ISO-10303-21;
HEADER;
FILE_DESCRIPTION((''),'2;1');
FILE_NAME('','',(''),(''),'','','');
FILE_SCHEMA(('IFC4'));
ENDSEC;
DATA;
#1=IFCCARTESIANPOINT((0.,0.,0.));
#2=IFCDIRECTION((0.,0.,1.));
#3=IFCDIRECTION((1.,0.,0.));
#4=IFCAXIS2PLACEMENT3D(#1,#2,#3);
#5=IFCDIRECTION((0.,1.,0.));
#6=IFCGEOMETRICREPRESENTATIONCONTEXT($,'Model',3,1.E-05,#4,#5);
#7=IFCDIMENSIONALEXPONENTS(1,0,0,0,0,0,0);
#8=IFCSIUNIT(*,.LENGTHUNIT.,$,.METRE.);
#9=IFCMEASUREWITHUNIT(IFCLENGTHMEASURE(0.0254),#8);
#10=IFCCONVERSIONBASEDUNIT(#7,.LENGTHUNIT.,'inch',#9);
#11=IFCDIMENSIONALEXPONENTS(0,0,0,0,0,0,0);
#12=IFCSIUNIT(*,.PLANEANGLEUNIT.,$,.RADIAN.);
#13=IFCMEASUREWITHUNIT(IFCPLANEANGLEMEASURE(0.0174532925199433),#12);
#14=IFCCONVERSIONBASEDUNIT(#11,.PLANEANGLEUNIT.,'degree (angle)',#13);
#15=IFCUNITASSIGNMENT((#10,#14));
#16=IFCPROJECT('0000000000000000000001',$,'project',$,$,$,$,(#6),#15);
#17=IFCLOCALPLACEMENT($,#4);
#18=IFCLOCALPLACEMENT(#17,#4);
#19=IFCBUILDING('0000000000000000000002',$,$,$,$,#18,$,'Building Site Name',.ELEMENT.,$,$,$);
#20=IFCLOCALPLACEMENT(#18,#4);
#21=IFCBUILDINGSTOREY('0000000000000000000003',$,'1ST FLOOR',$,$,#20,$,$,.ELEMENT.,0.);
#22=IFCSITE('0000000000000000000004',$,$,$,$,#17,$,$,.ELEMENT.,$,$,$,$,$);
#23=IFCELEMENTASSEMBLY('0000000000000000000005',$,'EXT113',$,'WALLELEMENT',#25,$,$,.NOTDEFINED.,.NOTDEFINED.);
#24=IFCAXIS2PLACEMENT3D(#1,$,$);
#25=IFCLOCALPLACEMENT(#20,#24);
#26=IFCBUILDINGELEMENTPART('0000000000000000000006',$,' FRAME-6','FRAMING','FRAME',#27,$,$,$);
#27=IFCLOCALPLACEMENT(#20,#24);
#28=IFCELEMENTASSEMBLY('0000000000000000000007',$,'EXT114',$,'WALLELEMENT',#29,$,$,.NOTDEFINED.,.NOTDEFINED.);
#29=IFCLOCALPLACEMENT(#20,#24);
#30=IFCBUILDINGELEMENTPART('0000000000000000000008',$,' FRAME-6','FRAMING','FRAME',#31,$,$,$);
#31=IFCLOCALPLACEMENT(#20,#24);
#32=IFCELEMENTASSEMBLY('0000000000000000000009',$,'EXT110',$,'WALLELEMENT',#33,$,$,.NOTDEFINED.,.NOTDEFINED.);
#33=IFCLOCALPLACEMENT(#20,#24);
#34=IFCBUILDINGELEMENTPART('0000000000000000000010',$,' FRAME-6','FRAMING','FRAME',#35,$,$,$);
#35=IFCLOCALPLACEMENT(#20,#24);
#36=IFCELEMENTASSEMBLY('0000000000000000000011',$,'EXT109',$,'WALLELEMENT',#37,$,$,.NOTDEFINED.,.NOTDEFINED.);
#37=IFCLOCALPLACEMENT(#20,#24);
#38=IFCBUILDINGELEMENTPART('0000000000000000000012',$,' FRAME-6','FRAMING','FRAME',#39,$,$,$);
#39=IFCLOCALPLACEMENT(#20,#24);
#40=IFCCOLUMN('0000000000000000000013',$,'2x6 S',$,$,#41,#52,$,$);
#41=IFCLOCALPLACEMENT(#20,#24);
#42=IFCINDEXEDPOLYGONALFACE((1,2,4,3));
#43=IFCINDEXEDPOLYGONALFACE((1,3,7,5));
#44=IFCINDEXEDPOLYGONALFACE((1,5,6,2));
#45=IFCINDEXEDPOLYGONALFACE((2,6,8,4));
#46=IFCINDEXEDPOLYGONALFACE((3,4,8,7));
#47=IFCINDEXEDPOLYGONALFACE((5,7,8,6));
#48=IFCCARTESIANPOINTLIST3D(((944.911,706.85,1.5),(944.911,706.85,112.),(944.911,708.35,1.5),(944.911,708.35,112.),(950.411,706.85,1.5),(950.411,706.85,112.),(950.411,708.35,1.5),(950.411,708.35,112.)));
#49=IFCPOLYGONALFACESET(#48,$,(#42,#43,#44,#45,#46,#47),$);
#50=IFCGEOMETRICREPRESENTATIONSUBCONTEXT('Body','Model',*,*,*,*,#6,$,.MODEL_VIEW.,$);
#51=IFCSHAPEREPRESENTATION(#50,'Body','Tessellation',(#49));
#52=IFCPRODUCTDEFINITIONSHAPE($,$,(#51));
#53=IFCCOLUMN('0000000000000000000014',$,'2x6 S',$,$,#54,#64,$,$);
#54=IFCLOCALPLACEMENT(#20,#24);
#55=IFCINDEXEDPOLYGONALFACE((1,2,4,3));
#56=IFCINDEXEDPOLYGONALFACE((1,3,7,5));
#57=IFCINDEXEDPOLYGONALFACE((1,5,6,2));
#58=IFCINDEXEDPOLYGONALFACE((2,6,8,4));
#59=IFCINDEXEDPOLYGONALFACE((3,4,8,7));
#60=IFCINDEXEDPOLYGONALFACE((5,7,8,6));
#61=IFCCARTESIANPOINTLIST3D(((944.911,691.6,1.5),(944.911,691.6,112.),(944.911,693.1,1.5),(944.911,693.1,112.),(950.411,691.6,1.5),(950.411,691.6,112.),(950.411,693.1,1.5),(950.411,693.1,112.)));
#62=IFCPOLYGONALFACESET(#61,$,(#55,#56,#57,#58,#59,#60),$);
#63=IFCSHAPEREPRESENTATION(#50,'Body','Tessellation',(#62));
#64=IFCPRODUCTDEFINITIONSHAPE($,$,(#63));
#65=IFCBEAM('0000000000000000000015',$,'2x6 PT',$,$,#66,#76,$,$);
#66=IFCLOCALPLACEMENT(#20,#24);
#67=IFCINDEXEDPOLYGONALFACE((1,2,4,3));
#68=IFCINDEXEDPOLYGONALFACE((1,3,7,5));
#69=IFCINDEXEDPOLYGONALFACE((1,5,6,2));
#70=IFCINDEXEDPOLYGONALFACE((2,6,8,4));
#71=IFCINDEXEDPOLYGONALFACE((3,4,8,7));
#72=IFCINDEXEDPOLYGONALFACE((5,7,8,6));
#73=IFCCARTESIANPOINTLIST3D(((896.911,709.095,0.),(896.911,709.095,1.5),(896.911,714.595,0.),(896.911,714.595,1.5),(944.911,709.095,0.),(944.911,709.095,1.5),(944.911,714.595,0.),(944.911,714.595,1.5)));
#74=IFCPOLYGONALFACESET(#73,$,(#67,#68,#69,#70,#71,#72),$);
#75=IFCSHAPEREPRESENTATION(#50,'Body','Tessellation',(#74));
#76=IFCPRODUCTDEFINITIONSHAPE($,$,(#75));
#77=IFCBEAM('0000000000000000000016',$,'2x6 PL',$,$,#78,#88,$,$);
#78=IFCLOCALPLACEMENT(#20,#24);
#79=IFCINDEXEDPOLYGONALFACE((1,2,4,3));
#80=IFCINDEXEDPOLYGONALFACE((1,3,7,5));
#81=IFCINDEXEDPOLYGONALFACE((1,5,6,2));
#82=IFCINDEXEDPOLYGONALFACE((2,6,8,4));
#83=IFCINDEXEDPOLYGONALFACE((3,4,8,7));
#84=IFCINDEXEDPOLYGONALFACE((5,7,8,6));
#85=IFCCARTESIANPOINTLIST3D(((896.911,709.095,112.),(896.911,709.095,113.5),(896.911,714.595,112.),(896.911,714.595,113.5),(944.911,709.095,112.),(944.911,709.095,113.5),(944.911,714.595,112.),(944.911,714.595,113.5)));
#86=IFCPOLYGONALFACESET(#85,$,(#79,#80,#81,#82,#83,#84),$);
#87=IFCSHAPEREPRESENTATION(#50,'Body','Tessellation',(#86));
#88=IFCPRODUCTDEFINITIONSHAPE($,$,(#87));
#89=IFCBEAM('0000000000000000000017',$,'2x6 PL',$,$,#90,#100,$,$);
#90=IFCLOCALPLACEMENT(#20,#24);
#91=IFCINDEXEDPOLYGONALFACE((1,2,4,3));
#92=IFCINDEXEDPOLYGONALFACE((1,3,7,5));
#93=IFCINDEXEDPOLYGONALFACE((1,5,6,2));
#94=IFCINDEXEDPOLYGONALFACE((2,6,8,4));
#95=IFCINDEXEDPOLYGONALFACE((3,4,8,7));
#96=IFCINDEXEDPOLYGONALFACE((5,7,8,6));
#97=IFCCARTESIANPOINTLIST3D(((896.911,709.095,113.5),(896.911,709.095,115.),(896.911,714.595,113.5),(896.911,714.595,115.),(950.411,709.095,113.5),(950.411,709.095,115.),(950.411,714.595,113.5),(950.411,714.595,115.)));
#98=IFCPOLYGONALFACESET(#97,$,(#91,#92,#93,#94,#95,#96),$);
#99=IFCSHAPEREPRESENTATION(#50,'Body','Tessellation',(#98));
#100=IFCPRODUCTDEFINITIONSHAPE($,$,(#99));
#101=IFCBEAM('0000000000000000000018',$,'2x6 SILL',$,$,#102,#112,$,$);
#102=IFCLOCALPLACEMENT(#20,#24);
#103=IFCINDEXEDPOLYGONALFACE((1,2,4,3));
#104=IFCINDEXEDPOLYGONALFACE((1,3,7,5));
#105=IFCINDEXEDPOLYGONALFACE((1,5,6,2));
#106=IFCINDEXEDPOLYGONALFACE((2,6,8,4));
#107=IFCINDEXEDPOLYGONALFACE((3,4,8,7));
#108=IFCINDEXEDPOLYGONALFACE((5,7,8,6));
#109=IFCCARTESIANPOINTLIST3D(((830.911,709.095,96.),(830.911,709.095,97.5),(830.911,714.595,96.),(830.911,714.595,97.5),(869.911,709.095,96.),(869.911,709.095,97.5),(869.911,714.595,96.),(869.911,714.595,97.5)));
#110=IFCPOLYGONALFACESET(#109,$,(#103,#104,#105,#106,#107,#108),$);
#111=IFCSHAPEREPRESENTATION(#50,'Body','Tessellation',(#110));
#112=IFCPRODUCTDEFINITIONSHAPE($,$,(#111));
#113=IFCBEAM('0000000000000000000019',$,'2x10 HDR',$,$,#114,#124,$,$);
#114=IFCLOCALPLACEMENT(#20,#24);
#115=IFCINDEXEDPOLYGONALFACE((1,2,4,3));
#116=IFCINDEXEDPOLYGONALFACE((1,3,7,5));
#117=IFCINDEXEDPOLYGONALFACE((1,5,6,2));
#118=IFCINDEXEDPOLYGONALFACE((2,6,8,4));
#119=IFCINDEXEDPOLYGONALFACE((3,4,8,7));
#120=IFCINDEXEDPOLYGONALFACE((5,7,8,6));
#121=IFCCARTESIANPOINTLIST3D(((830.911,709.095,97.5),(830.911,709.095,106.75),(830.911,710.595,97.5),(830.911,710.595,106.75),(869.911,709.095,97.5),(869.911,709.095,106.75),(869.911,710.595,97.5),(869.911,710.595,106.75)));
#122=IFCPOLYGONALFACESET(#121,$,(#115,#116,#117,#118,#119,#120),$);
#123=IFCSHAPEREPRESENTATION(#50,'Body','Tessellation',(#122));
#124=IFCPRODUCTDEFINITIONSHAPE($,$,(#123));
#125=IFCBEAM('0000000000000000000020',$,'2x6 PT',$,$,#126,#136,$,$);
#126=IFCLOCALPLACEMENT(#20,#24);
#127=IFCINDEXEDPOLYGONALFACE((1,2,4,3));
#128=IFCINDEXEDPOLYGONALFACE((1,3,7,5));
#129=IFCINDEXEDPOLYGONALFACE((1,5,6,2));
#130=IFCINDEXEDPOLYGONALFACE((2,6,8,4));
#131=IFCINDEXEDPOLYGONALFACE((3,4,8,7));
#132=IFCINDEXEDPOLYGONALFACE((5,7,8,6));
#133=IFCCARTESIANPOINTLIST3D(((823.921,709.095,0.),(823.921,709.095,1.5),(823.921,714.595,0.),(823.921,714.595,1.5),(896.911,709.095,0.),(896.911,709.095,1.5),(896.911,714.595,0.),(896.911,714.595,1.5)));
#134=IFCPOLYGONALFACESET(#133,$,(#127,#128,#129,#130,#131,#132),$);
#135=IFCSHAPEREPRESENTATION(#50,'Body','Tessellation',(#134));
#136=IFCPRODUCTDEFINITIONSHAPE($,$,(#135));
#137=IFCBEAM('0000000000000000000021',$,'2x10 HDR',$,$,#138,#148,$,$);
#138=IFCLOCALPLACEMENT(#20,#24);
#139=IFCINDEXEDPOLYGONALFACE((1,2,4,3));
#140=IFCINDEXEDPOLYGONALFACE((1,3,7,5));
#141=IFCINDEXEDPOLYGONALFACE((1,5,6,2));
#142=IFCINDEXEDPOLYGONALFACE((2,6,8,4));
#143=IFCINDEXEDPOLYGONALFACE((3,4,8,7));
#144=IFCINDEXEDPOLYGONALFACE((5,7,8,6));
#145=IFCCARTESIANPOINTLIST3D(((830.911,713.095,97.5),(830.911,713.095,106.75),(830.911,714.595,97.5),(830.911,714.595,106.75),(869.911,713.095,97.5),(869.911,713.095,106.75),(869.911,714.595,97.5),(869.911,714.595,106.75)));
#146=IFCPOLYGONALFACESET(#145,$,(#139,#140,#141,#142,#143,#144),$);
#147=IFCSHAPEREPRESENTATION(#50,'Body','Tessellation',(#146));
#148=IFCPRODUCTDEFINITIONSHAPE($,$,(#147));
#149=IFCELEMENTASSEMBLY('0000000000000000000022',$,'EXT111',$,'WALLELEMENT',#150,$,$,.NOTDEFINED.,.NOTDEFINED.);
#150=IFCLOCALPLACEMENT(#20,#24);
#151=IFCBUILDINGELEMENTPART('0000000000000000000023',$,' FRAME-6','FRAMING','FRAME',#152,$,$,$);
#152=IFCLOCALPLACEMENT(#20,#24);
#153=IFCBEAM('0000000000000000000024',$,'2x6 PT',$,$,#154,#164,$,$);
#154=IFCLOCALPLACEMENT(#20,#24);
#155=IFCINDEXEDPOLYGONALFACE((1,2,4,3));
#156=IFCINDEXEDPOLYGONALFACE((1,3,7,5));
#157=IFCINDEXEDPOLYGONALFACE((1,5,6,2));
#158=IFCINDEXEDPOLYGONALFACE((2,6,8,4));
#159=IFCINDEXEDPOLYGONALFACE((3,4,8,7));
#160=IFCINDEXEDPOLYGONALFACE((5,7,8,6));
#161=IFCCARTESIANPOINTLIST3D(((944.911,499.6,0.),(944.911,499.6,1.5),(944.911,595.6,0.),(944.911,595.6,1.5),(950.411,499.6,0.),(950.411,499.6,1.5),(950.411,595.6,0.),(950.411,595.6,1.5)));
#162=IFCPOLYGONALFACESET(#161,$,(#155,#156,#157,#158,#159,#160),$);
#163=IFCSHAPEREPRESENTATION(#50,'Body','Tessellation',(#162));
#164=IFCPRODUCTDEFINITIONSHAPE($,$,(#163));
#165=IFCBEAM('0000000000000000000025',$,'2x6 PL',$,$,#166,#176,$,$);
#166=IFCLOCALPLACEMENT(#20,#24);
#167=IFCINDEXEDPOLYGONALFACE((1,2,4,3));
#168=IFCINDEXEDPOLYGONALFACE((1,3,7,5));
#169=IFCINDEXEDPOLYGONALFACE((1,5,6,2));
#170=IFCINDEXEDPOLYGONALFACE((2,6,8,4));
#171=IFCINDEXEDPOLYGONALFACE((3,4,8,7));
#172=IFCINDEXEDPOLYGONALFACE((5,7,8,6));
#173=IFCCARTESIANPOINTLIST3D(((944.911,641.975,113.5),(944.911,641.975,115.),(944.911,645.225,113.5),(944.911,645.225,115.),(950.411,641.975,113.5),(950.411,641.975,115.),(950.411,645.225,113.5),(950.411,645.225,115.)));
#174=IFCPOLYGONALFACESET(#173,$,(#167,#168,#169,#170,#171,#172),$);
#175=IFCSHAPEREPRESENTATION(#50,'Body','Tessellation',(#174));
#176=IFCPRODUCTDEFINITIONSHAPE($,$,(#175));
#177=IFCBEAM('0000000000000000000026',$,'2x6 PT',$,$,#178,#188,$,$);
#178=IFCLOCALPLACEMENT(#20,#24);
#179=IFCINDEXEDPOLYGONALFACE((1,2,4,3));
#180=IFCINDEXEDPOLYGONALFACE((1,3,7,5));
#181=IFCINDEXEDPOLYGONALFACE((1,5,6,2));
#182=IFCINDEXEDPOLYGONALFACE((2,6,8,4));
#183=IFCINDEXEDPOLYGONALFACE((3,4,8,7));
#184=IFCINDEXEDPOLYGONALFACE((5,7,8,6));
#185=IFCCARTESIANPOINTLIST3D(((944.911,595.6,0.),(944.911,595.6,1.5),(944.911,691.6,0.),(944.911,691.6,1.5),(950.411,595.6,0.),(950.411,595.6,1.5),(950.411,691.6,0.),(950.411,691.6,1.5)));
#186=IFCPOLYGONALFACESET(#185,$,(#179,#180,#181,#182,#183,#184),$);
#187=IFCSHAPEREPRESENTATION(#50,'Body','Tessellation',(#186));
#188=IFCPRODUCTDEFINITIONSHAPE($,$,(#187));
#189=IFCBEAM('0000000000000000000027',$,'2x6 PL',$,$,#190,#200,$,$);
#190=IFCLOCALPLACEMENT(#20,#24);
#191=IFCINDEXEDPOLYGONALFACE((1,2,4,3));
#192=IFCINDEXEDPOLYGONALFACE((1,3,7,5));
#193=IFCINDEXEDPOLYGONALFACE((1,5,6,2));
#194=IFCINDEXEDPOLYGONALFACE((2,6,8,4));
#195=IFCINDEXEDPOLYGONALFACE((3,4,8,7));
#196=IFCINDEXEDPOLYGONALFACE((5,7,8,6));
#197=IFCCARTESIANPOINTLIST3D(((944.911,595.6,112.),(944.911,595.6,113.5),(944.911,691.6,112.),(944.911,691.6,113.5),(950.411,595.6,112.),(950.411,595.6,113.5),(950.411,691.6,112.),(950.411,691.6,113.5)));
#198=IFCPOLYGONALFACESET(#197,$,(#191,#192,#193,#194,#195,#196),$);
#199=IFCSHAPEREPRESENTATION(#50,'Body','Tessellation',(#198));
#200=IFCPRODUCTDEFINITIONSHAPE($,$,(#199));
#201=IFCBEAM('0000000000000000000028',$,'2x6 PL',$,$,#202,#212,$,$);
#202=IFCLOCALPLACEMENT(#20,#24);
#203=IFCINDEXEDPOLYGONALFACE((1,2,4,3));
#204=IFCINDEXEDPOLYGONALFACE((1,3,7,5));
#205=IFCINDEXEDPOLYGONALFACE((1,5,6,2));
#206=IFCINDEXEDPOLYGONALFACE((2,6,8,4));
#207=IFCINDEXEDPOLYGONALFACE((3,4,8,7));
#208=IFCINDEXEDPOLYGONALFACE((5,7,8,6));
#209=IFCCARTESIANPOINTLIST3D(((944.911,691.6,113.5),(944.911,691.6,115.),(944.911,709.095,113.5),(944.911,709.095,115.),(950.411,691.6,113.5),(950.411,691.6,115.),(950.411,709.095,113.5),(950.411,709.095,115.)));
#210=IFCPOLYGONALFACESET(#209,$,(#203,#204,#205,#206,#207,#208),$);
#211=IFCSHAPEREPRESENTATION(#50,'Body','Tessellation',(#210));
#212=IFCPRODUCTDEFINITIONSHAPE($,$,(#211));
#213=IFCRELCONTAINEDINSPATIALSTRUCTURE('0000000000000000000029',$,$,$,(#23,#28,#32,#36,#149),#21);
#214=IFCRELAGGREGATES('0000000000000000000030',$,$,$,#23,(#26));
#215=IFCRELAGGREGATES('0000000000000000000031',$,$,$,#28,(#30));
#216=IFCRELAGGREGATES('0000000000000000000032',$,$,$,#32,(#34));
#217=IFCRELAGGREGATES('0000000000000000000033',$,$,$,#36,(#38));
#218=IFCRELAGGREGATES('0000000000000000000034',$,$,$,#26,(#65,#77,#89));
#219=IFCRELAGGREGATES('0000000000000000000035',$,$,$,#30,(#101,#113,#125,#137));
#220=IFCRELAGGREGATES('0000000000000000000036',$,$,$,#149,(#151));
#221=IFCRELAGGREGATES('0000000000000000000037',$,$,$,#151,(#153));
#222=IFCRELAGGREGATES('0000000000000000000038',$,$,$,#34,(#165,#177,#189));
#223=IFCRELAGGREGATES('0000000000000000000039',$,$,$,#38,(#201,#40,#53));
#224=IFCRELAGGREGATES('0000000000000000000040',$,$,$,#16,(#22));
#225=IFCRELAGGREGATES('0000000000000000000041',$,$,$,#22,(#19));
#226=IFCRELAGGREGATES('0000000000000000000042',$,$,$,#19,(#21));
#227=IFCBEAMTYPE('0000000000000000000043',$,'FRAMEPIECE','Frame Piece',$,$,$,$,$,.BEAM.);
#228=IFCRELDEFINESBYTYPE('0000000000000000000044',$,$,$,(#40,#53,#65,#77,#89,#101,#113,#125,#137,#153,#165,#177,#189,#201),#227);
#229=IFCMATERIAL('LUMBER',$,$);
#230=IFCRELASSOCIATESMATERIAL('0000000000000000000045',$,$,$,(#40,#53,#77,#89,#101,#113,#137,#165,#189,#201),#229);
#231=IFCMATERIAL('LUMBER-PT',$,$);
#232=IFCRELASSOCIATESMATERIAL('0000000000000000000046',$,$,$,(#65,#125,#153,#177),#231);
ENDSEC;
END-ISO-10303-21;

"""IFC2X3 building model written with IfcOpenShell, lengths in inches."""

from ifc_helpers import new_model, entity, si_unit, converted_unit, direction, frame, frame_2d, origin_with_axes, place, context, subcontext, project, spatial, rectangle, extrude, material, type_object, element, aggregate, save


model = new_model("IFC2X3")

# Units and contexts
model_context = context("Model", 3, precision=1e-05, world=origin_with_axes(), true_north=direction((0.0, 1.0, 0.0)))
body_context = subcontext(model_context, "Body", "Model", "MODEL_VIEW")
ifc_project = project(units=[converted_unit("LENGTHUNIT", "inch", entity("IfcLengthMeasure", 0.0254), si_unit("LENGTHUNIT", "METRE"), dimensions=[1, 0, 0, 0, 0, 0, 0]), converted_unit("PLANEANGLEUNIT", "degree (angle)", entity("IfcPlaneAngleMeasure", 0.0174532925199433), si_unit("PLANEANGLEUNIT", "RADIAN"), dimensions=[0, 0, 0, 0, 0, 0, 0])], contexts=[model_context])

# Site, building, storey
site_placement = place(None, origin_with_axes())
site = spatial("IfcSite", under=ifc_project, at=site_placement, CompositionType="ELEMENT")
building_placement = place(site_placement, origin_with_axes())
building = spatial("IfcBuilding", under=site, at=building_placement, LongName="Building Site Name", CompositionType="ELEMENT")
storey_placement = place(building_placement, origin_with_axes())
storey = spatial("IfcBuildingStorey", under=building, at=storey_placement, Name="1ST FLOOR", CompositionType="ELEMENT", Elevation=0.0)

# Element assemblies, building element parts, columns
assembly_1_placement = place(storey_placement, origin_with_axes())
assembly_1 = element("IfcElementAssembly", 1, at=assembly_1_placement, inside=storey, Name="EXT113", ObjectType="WALLELEMENT", AssemblyPlace="NOTDEFINED", PredefinedType="NOTDEFINED")
building_element_part_1 = element("IfcBuildingElementPart", 2, Name=" FRAME-6", Description="FRAMING", ObjectType="FRAME")
aggregate(assembly_1, [building_element_part_1])
ifc_material_1 = material(Name="LUMBER")
beam_type = type_object("IfcBeamType", Name="FRAMEPIECE", Description="Frame Piece", PredefinedType="BEAM")
assembly_2_placement = place(storey_placement, origin_with_axes())
assembly_2 = element("IfcElementAssembly", 3, at=assembly_2_placement, inside=storey, Name="EXT114", ObjectType="WALLELEMENT", AssemblyPlace="NOTDEFINED", PredefinedType="NOTDEFINED")
building_element_part_2 = element("IfcBuildingElementPart", 4, Name=" FRAME-6", Description="FRAMING", ObjectType="FRAME")
aggregate(assembly_2, [building_element_part_2])
assembly_3_placement = place(storey_placement, origin_with_axes())
assembly_3 = element("IfcElementAssembly", 5, at=assembly_3_placement, inside=storey, Name="EXT110", ObjectType="WALLELEMENT", AssemblyPlace="NOTDEFINED", PredefinedType="NOTDEFINED")
building_element_part_3 = element("IfcBuildingElementPart", 6, Name=" FRAME-6", Description="FRAMING", ObjectType="FRAME")
aggregate(assembly_3, [building_element_part_3])
assembly_4_placement = place(storey_placement, origin_with_axes())
assembly_4 = element("IfcElementAssembly", 7, at=assembly_4_placement, inside=storey, Name="EXT109", ObjectType="WALLELEMENT", AssemblyPlace="NOTDEFINED", PredefinedType="NOTDEFINED")
building_element_part_4 = element("IfcBuildingElementPart", 8, Name=" FRAME-6", Description="FRAMING", ObjectType="FRAME")
aggregate(assembly_4, [building_element_part_4])
column_1_placement = place(assembly_4_placement, frame((947.661, 707.6, 112.0), z_axis=(0.0, 0.0, -1.0), x_axis=(0.0, -1.0, 0.0)))
column_1 = element("IfcColumn", 9, at=column_1_placement, type_object=beam_type, material=ifc_material_1, Name="2x6 S", context=body_context, shape_type="SweptSolid", body=[
    extrude(rectangle(XDim=1.5, YDim=5.5, at=frame_2d((0.0, 0.0), x_axis=(-1.0, 0.0))), origin_with_axes(), (0.0, 0.0, 1.0), 110.5),
])
column_2_placement = place(assembly_4_placement, frame((947.661, 692.35, 1.5), z_axis=(0.0, 0.0, 1.0), x_axis=(0.0, 1.0, 0.0)))
column_2 = element("IfcColumn", 10, at=column_2_placement, type_object=beam_type, material=ifc_material_1, Name="2x6 S", context=body_context, shape_type="SweptSolid", body=[
    extrude(rectangle(XDim=1.5, YDim=5.5, at=frame_2d((0.0, 0.0), x_axis=(-1.0, 0.0))), frame((0.0, 0.0, 0.0), z_axis=(0.0, 0.0, 1.0), x_axis=(1.0, 0.0, 0.0)), (0.0, 0.0, 1.0), 110.5),
])

# Beams
ifc_material_2 = material(Name="LUMBER-PT")
beam_1_placement = place(assembly_1_placement, frame((944.911, 711.845, 0.75), z_axis=(-1.0, 0.0, 0.0), x_axis=(0.0, 0.0, 1.0)))
beam_1 = element("IfcBeam", 11, at=beam_1_placement, type_object=beam_type, material=ifc_material_2, Name="2x6 PT", context=body_context, shape_type="SweptSolid", body=[
    extrude(rectangle(XDim=1.5, YDim=5.5, at=frame_2d((0.0, 0.0), x_axis=(-1.0, 0.0))), origin_with_axes(), (0.0, 0.0, 1.0), 48.0),
])
beam_2_placement = place(assembly_1_placement, frame((896.911, 711.845, 112.75), z_axis=(1.0, 0.0, 0.0), x_axis=(0.0, 0.0, -1.0)))
beam_2 = element("IfcBeam", 12, at=beam_2_placement, type_object=beam_type, material=ifc_material_1, Name="2x6 PL", context=body_context, shape_type="SweptSolid", body=[
    extrude(rectangle(XDim=1.5, YDim=5.5, at=frame_2d((0.0, 0.0), x_axis=(-1.0, 0.0))), origin_with_axes(), (0.0, 0.0, 1.0), 48.0),
])
beam_3_placement = place(assembly_1_placement, frame((896.911, 711.845, 114.25), z_axis=(1.0, 0.0, 0.0), x_axis=(0.0, 0.0, -1.0)))
beam_3 = element("IfcBeam", 13, at=beam_3_placement, type_object=beam_type, material=ifc_material_1, Name="2x6 PL", context=body_context, shape_type="SweptSolid", body=[
    extrude(rectangle(XDim=1.5, YDim=5.5, at=frame_2d((0.0, 0.0), x_axis=(-1.0, 0.0))), origin_with_axes(), (0.0, 0.0, 1.0), 53.5),
])
aggregate(building_element_part_1, [beam_1, beam_2, beam_3])
beam_4_placement = place(assembly_2_placement, frame((869.911, 711.845, 96.75), z_axis=(-1.0, 0.0, 0.0), x_axis=(0.0, 0.0, 1.0)))
beam_4 = element("IfcBeam", 14, at=beam_4_placement, type_object=beam_type, material=ifc_material_1, Name="2x6 SILL", context=body_context, shape_type="SweptSolid", body=[
    extrude(rectangle(XDim=1.5, YDim=5.5, at=frame_2d((0.0, 0.0), x_axis=(-1.0, 0.0))), frame((0.0, 0.0, 0.0), z_axis=(0.0, 0.0, 1.0), x_axis=(1.0, 0.0, 0.0)), (0.0, 0.0, 1.0), 39.0),
])
beam_5_placement = place(assembly_2_placement, frame((869.911, 709.845, 102.125), z_axis=(-1.0, 0.0, 0.0), x_axis=(0.0, -1.0, 0.0)))
beam_5 = element("IfcBeam", 15, at=beam_5_placement, type_object=beam_type, material=ifc_material_1, Name="2x10 HDR", context=body_context, shape_type="SweptSolid", body=[
    extrude(rectangle(XDim=1.5, YDim=9.25, at=frame_2d((0.0, 0.0), x_axis=(-1.0, 0.0))), origin_with_axes(), (0.0, 0.0, 1.0), 39.0),
])
beam_6_placement = place(assembly_2_placement, frame((896.911, 711.845, 0.75), z_axis=(-1.0, 0.0, 0.0), x_axis=(0.0, 0.0, 1.0)))
beam_6 = element("IfcBeam", 16, at=beam_6_placement, type_object=beam_type, material=ifc_material_2, Name="2x6 PT", context=body_context, shape_type="SweptSolid", body=[
    extrude(rectangle(XDim=1.5, YDim=5.5, at=frame_2d((0.0, 0.0), x_axis=(-1.0, 0.0))), origin_with_axes(), (0.0, 0.0, 1.0), 72.99),
])
beam_7_placement = place(assembly_2_placement, frame((869.911, 713.845, 102.125), z_axis=(-1.0, 0.0, 0.0), x_axis=(0.0, -1.0, 0.0)))
beam_7 = element("IfcBeam", 17, at=beam_7_placement, type_object=beam_type, material=ifc_material_1, Name="2x10 HDR", context=body_context, shape_type="SweptSolid", body=[
    extrude(rectangle(XDim=1.5, YDim=9.25, at=frame_2d((0.0, 0.0), x_axis=(-1.0, 0.0))), origin_with_axes(), (0.0, 0.0, 1.0), 39.0),
])
aggregate(building_element_part_2, [beam_4, beam_5, beam_6, beam_7])

# Element assembly, building element part, beam
assembly_5_placement = place(storey_placement, origin_with_axes())
assembly_5 = element("IfcElementAssembly", 18, at=assembly_5_placement, inside=storey, Name="EXT111", ObjectType="WALLELEMENT", AssemblyPlace="NOTDEFINED", PredefinedType="NOTDEFINED")
building_element_part_5 = element("IfcBuildingElementPart", 19, Name=" FRAME-6", Description="FRAMING", ObjectType="FRAME")
aggregate(assembly_5, [building_element_part_5])
beam_8_placement = place(assembly_5_placement, frame((947.661, 595.6, 0.75), z_axis=(0.0, -1.0, 0.0), x_axis=(0.0, 0.0, 1.0)))
beam_8 = element("IfcBeam", 20, at=beam_8_placement, type_object=beam_type, material=ifc_material_2, Name="2x6 PT", context=body_context, shape_type="SweptSolid", body=[
    extrude(rectangle(XDim=1.5, YDim=5.5, at=frame_2d((0.0, 0.0), x_axis=(-1.0, 0.0))), origin_with_axes(), (0.0, 0.0, 1.0), 96.0),
])
aggregate(building_element_part_5, [beam_8])

# Beams
beam_9_placement = place(assembly_3_placement, frame((947.661, 641.975, 114.25), z_axis=(0.0, 1.0, 0.0), x_axis=(0.0, 0.0, -1.0)))
beam_9 = element("IfcBeam", 21, at=beam_9_placement, type_object=beam_type, material=ifc_material_1, Name="2x6 PL", context=body_context, shape_type="SweptSolid", body=[
    extrude(rectangle(XDim=1.5, YDim=5.5, at=frame_2d((0.0, 0.0), x_axis=(-1.0, 0.0))), origin_with_axes(), (0.0, 0.0, 1.0), 3.25),
])
beam_10_placement = place(assembly_3_placement, frame((947.661, 691.6, 0.75), z_axis=(0.0, -1.0, 0.0), x_axis=(0.0, 0.0, 1.0)))
beam_10 = element("IfcBeam", 22, at=beam_10_placement, type_object=beam_type, material=ifc_material_2, Name="2x6 PT", context=body_context, shape_type="SweptSolid", body=[
    extrude(rectangle(XDim=1.5, YDim=5.5, at=frame_2d((0.0, 0.0), x_axis=(-1.0, 0.0))), origin_with_axes(), (0.0, 0.0, 1.0), 96.0),
])
beam_11_placement = place(assembly_3_placement, frame((947.661, 595.6, 112.75), z_axis=(0.0, 1.0, 0.0), x_axis=(0.0, 0.0, -1.0)))
beam_11 = element("IfcBeam", 23, at=beam_11_placement, type_object=beam_type, material=ifc_material_1, Name="2x6 PL", context=body_context, shape_type="SweptSolid", body=[
    extrude(rectangle(XDim=1.5, YDim=5.5, at=frame_2d((0.0, 0.0), x_axis=(-1.0, 0.0))), origin_with_axes(), (0.0, 0.0, 1.0), 96.0),
])
aggregate(building_element_part_3, [beam_9, beam_10, beam_11])
beam_12_placement = place(assembly_4_placement, frame((947.661, 691.6, 114.25), z_axis=(0.0, 1.0, 0.0), x_axis=(0.0, 0.0, -1.0)))
beam_12 = element("IfcBeam", 24, at=beam_12_placement, type_object=beam_type, material=ifc_material_1, Name="2x6 PL", context=body_context, shape_type="SweptSolid", body=[
    extrude(rectangle(XDim=1.5, YDim=5.5, at=frame_2d((0.0, 0.0), x_axis=(-1.0, 0.0))), origin_with_axes(), (0.0, 0.0, 1.0), 17.495),
])
aggregate(building_element_part_4, [beam_12, column_1, column_2])

save(model, "model.ifc")
